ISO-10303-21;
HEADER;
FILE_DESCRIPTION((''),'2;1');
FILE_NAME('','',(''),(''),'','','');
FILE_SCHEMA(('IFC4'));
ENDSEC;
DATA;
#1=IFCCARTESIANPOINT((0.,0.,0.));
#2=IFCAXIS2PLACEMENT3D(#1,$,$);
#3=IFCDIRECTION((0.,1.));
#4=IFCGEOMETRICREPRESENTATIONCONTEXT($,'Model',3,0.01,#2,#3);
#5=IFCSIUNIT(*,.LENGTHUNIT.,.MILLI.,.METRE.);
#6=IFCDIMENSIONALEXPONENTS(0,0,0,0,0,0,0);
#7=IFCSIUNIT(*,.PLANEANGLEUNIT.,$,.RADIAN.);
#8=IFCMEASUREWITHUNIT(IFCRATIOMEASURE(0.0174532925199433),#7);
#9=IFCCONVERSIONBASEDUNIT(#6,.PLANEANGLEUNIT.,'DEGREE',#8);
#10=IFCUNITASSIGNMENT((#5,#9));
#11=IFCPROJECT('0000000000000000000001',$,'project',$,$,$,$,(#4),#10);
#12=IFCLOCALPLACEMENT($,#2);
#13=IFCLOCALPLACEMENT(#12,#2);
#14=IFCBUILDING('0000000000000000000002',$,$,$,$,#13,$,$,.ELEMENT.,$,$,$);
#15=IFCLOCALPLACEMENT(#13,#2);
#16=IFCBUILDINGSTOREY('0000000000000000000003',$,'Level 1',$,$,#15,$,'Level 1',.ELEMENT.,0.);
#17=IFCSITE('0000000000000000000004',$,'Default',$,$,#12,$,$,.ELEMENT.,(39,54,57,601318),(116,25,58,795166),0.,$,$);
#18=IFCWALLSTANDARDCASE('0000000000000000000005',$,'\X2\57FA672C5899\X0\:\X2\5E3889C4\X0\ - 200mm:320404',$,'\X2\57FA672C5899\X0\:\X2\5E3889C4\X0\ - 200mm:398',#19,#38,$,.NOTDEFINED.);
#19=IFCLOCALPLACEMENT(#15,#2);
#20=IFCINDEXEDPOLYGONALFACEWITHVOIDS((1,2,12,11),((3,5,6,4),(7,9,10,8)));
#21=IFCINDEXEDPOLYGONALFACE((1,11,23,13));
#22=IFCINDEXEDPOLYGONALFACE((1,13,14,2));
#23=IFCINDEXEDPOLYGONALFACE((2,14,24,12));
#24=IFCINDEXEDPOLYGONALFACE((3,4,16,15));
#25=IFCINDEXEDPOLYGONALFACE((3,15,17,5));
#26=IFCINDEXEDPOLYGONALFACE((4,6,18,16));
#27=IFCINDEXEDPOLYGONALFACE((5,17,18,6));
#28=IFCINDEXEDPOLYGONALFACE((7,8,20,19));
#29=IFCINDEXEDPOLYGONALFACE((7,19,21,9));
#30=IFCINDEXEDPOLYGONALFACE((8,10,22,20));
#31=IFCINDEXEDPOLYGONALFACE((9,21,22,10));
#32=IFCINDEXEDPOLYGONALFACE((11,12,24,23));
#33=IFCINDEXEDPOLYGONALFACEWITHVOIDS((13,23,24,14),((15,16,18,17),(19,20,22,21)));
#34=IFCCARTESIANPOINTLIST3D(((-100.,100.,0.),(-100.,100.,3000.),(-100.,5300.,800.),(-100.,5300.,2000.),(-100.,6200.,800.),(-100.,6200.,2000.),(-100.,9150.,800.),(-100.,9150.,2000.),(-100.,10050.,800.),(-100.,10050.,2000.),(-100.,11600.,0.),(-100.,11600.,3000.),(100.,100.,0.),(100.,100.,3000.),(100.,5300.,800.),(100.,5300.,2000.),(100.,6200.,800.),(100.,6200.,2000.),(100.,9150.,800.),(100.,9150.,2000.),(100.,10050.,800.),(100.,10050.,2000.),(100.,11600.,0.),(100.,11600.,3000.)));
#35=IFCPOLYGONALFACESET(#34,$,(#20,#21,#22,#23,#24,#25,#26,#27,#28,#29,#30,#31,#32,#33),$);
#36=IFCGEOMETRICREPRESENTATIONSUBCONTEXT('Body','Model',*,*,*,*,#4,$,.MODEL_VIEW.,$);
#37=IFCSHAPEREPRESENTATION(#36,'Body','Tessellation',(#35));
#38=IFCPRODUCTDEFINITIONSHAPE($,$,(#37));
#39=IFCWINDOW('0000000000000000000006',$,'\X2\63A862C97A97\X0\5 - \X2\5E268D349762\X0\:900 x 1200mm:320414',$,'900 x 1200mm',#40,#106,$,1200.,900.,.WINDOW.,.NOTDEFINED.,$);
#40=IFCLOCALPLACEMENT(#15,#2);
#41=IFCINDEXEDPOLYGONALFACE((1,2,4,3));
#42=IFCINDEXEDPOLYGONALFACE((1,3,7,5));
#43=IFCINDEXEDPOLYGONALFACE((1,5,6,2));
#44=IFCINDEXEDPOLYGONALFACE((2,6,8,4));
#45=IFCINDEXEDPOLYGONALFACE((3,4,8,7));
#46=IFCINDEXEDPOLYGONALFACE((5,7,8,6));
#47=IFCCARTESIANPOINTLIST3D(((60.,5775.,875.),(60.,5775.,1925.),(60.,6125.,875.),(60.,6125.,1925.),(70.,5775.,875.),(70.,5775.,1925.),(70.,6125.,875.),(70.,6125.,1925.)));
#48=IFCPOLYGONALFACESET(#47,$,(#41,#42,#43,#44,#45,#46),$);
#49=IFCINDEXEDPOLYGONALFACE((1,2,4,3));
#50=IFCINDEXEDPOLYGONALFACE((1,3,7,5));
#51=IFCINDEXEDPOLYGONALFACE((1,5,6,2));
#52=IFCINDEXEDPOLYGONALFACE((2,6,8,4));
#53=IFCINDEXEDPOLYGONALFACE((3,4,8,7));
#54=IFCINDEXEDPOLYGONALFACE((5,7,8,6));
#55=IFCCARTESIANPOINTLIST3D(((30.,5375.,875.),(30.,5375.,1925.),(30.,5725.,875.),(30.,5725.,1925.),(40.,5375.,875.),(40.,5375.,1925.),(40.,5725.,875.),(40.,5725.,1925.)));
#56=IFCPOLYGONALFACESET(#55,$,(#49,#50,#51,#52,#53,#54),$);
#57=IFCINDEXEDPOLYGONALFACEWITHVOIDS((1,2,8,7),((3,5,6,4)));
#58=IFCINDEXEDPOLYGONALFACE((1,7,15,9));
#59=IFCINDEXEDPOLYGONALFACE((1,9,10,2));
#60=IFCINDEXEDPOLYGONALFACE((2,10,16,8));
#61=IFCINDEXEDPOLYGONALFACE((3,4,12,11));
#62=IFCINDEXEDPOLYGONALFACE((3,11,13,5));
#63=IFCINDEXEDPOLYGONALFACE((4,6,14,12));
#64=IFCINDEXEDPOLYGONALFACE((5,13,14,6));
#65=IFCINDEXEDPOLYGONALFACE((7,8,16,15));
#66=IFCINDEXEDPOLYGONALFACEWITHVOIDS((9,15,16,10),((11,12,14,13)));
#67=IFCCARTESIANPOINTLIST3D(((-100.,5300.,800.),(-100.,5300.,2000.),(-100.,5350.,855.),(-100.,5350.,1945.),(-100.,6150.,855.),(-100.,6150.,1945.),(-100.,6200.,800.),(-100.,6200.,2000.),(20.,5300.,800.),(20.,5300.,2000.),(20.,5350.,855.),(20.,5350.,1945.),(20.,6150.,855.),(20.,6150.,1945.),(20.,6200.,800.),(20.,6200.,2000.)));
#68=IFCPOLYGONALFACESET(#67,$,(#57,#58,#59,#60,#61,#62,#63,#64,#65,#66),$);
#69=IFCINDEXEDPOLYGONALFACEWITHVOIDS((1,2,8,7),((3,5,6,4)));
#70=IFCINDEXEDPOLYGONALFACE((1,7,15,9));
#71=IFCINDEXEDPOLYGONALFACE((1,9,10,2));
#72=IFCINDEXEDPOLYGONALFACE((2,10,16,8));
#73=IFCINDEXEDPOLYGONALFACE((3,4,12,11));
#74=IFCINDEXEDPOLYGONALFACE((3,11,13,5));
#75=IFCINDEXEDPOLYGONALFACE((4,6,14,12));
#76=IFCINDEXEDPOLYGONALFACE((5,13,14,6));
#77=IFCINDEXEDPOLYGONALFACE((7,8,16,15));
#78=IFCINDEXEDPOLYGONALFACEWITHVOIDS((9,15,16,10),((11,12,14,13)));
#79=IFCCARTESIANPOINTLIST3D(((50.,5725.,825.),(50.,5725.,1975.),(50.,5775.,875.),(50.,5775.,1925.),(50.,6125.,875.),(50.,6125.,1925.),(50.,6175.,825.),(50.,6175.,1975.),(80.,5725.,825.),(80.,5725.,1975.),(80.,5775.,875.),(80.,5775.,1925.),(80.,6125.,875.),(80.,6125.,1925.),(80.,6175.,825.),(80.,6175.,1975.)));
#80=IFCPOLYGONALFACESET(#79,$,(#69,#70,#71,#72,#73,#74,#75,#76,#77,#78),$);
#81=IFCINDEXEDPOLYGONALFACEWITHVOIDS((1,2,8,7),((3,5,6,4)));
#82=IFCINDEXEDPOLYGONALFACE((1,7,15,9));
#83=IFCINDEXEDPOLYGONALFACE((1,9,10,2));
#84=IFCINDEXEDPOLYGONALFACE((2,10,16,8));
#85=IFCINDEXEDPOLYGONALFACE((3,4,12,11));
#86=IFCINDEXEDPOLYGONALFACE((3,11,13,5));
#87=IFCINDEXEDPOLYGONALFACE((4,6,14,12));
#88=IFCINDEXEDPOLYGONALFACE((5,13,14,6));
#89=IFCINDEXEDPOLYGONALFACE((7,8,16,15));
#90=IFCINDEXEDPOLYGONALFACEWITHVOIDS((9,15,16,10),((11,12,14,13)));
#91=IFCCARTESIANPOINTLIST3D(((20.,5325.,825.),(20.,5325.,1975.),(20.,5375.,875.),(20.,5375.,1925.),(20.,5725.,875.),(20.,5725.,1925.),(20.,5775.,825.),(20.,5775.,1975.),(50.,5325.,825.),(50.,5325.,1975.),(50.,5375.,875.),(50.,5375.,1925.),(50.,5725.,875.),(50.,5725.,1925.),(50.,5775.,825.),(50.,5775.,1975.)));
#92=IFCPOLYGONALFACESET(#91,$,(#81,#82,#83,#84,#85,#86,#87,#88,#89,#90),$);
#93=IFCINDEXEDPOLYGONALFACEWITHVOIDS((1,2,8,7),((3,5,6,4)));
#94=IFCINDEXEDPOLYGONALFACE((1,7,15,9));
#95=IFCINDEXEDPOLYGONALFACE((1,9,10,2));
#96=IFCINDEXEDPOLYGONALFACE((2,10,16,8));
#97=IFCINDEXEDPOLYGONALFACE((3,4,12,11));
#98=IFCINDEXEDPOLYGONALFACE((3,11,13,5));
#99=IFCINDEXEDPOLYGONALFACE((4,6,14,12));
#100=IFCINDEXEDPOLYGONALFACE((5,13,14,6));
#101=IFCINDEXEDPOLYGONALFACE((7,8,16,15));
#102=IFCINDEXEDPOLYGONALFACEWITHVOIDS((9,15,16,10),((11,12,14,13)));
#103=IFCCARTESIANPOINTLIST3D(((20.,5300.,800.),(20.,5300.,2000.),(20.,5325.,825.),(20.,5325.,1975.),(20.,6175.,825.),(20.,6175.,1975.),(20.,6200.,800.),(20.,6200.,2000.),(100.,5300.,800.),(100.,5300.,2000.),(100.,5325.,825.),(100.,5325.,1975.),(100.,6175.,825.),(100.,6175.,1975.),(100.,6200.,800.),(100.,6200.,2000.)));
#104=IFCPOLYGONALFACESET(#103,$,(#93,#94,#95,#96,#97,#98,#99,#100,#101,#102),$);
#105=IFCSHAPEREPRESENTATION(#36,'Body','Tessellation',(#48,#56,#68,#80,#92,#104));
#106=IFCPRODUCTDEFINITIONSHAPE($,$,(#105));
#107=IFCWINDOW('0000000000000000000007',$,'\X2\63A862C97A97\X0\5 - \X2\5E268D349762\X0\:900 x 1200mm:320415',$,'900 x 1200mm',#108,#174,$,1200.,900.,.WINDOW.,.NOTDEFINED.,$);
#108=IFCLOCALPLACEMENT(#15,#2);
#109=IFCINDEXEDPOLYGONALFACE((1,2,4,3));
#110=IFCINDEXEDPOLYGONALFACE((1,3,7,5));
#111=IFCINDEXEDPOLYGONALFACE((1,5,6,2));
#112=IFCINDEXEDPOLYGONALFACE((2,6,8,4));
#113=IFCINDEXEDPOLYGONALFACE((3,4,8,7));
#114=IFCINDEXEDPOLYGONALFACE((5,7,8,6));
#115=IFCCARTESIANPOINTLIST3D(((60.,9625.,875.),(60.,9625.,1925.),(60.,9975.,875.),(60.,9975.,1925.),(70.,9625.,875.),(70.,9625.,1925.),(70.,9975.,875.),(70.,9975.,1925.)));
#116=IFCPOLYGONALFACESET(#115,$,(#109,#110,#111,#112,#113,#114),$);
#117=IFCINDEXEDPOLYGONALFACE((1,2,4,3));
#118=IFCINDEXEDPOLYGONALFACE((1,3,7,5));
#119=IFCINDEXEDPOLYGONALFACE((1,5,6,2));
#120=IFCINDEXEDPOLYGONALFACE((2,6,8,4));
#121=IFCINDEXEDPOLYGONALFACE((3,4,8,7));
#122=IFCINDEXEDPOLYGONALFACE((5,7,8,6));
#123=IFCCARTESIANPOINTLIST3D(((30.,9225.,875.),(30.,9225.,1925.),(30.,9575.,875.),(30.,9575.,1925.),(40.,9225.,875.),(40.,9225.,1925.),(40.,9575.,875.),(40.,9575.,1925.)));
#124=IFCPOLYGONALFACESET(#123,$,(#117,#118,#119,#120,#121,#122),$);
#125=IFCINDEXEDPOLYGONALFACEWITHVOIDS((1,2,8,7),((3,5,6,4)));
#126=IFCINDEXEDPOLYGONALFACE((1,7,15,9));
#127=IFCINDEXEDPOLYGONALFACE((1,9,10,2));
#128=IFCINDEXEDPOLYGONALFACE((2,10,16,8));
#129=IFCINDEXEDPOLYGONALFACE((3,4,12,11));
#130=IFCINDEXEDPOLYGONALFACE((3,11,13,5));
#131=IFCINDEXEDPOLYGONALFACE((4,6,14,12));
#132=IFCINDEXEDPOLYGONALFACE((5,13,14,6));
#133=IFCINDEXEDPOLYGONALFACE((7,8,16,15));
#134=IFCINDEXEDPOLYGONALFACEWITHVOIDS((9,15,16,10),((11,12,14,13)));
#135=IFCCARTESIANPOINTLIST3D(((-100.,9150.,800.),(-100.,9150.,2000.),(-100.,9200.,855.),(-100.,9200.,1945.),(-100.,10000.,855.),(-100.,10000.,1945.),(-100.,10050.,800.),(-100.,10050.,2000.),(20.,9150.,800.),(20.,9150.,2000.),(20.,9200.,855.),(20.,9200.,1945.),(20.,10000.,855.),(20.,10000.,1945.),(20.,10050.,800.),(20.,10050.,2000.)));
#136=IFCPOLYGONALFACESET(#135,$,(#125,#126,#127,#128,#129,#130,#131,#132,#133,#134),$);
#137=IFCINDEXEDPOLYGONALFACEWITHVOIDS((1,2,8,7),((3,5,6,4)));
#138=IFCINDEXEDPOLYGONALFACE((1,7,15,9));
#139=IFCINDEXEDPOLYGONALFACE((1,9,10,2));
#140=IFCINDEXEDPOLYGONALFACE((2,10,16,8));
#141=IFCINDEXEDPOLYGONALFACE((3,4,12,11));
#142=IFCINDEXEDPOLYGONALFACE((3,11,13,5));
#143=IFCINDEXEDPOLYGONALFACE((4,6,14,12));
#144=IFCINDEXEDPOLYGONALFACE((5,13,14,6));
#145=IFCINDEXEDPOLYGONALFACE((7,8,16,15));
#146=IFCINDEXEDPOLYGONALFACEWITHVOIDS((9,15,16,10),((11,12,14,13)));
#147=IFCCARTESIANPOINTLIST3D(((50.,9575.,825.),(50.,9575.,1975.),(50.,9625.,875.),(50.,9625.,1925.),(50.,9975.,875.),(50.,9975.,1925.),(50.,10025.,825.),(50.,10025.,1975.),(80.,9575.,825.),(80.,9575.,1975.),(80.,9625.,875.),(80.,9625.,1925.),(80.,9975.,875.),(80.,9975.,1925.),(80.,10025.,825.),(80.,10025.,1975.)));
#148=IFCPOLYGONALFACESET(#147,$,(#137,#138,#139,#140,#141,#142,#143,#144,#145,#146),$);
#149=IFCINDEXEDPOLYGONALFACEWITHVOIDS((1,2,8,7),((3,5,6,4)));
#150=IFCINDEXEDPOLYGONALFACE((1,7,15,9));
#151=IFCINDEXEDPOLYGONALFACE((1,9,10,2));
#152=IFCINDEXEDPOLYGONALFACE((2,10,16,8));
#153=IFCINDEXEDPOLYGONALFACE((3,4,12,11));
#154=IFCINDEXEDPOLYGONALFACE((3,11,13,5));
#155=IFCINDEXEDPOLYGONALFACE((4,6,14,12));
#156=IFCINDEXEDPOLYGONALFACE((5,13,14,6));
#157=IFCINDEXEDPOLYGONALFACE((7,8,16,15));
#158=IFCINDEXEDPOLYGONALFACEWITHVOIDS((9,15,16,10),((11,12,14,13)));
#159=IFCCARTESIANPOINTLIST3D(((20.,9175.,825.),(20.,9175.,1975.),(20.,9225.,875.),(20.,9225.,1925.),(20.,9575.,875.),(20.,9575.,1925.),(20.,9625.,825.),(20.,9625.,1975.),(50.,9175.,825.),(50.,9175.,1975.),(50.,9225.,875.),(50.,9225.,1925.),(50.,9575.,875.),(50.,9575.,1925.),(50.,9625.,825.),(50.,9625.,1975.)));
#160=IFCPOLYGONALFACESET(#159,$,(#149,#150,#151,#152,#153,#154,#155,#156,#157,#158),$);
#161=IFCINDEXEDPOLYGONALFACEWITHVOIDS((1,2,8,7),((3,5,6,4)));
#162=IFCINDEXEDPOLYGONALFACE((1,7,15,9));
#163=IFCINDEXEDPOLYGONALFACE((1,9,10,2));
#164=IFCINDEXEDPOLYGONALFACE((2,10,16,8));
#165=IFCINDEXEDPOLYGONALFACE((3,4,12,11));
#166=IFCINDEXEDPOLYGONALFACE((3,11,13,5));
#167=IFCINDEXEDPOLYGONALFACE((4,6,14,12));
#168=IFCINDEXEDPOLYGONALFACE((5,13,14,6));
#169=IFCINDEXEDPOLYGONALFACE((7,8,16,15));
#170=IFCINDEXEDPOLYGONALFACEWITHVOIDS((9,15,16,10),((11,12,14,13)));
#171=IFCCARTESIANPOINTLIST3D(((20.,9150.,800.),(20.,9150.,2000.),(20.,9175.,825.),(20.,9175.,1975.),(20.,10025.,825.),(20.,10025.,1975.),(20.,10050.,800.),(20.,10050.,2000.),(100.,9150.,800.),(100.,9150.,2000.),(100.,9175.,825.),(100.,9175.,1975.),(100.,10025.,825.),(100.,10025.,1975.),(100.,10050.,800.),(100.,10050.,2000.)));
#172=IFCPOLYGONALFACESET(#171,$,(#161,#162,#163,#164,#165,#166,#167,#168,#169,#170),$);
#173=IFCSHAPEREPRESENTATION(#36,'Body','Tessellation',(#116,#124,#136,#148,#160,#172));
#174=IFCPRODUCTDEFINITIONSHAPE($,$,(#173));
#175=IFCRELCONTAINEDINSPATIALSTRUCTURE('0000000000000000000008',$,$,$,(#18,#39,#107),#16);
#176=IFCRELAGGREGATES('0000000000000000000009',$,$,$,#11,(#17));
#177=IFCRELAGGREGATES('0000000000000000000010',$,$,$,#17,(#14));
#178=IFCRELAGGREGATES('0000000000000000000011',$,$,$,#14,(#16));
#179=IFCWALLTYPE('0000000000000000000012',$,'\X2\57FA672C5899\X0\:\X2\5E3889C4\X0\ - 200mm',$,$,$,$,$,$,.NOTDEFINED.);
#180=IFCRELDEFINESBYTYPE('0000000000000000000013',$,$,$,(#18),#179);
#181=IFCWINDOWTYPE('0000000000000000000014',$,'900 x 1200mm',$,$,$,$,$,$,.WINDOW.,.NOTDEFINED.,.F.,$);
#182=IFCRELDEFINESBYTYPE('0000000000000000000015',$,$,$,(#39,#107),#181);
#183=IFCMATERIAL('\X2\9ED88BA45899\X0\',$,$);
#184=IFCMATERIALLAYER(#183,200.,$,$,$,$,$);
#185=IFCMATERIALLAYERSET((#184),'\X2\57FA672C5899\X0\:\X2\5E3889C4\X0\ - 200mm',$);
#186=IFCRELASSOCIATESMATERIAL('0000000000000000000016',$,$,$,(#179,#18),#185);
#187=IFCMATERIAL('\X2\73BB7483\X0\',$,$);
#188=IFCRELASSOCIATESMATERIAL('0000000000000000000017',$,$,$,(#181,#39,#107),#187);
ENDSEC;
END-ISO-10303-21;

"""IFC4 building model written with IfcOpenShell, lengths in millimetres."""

from ifc_helpers import new_model, entity, si_unit, converted_unit, direction, frame, frame_2d, origin, origin_2d_with_axis, place, context, subcontext, project, spatial, polyline, rectangle, outline, extrude, source, transform, mapped, material, layer, layer_set, layer_usage, type_object, type_shapes, element, fill, save


model = new_model("IFC4")

# Units and contexts
model_context = context("Model", 3, precision=0.01, world=origin(), true_north=direction((0.0, 1.0)))
body_context = subcontext(model_context, "Body", "Model", "MODEL_VIEW")
ifc_project = project(units=[si_unit("LENGTHUNIT", "METRE", prefix="MILLI"), converted_unit("PLANEANGLEUNIT", "DEGREE", entity("IfcRatioMeasure", 0.0174532925199433), si_unit("PLANEANGLEUNIT", "RADIAN"), dimensions=[0, 0, 0, 0, 0, 0, 0])], contexts=[model_context])

# Site, building, storey
site_placement = place(None, origin())
site = spatial("IfcSite", under=ifc_project, at=site_placement, Name="Default", CompositionType="ELEMENT", RefLatitude=(39, 54, 57, 601318), RefLongitude=(116, 25, 58, 795166), RefElevation=0.0)
building_placement = place(site_placement, origin())
building = spatial("IfcBuilding", under=site, at=building_placement, CompositionType="ELEMENT")
storey_placement = place(building_placement, origin())
storey = spatial("IfcBuildingStorey", under=building, at=storey_placement, Name="Level 1", LongName="Level 1", CompositionType="ELEMENT", Elevation=0.0)

# Wall, openings, windows
ifc_material_1 = material(Name="默认墙")
ifc_layer_1 = layer(ifc_material_1, 200.0)
ifc_layer_set_1 = layer_set([ifc_layer_1], Name="基本墙:常规 - 200mm")
ifc_layer_usage_1 = layer_usage(ifc_layer_set_1, "AXIS2", "NEGATIVE", 100.0)
wall_type = type_object("IfcWallType", Name="基本墙:常规 - 200mm", PredefinedType="NOTDEFINED", material=ifc_layer_set_1)
wall_1_placement = place(storey_placement, frame((0.0, 100.0, 0.0), z_axis=(0.0, 0.0, 1.0), x_axis=(0.0, 1.0, 0.0)))
wall_1 = element("IfcWallStandardCase", 1, at=wall_1_placement, inside=storey, type_object=wall_type, material=ifc_layer_usage_1, Name="基本墙:常规 - 200mm:320404", ObjectType="基本墙:常规 - 200mm:398", PredefinedType="NOTDEFINED", context=body_context, shape_type="SweptSolid", body=[
    extrude(rectangle(XDim=11500.0, YDim=200.0, at=frame_2d((5750.0, 0.0), x_axis=(-1.0, 0.0))), origin(), (0.0, 0.0, 1.0), 3000.0),
])
opening_1_placement = place(wall_1_placement, frame((6100.0, 100.0, 800.0)))
opening_1 = element("IfcOpeningElement", 2, at=opening_1_placement, cuts=wall_1, ObjectType="Opening", PredefinedType="OPENING", context=body_context, shape_type="SweptSolid", body=[
    extrude(rectangle(XDim=1200.0, YDim=900.0, at=frame_2d((600.0, 450.0), x_axis=(-1.0, 0.0))), frame((0.0, 0.0, 0.0), z_axis=(0.0, -1.0, 0.0), x_axis=(0.0, 0.0, 1.0)), (0.0, 0.0, 1.0), 200.0),
])
opening_2_placement = place(wall_1_placement, frame((9950.0, 100.0, 800.0)))
opening_2 = element("IfcOpeningElement", 3, at=opening_2_placement, cuts=wall_1, ObjectType="Opening", PredefinedType="OPENING", context=body_context, shape_type="SweptSolid", body=[
    extrude(rectangle(XDim=1200.0, YDim=900.0, at=frame_2d((600.0, 450.0), x_axis=(-1.0, 0.0))), frame((0.0, 0.0, 0.0), z_axis=(0.0, -1.0, 0.0), x_axis=(0.0, 0.0, 1.0)), (0.0, 0.0, 1.0), 200.0),
])
ifc_material_2 = material(Name="玻璃")
window_type_1 = type_object("IfcWindowType", Name="900 x 1200mm", ParameterTakesPrecedence=False, PartitioningType="NOTDEFINED", PredefinedType="WINDOW", material=ifc_material_2)
shared_shape_1 = source(origin(), body_context, "Body", "SweptSolid", [
    extrude(rectangle(XDim=10.0, YDim=350.0, at=origin_2d_with_axis()), frame((250.0, 165.0, 75.0), z_axis=(0.0, 0.0, 1.0), x_axis=(0.0, -1.0, 0.0)), (0.0, 0.0, 1.0), 1050.0),
    extrude(rectangle(XDim=10.0, YDim=350.0, at=origin_2d_with_axis()), frame((650.0, 135.0, 75.0), z_axis=(0.0, 0.0, 1.0), x_axis=(0.0, -1.0, 0.0)), (0.0, 0.0, 1.0), 1050.0),
    extrude(outline(polyline([(-450.0, -600.0), (450.0, -600.0), (450.0, 600.0), (-450.0, 600.0), (-450.0, -600.0)]), holes=[polyline([(400.0, -545.0), (-400.0, -545.0), (-400.0, 545.0), (400.0, 545.0), (400.0, -545.0)])]), frame((450.0, 0.0, 600.0), z_axis=(0.0, 1.0, 0.0), x_axis=(1.0, 0.0, 0.0)), (0.0, 0.0, 1.0), 120.0),
    extrude(outline(polyline([(-225.0, -575.0), (225.0, -575.0), (225.0, 575.0), (-225.0, 575.0), (-225.0, -575.0)]), holes=[polyline([(-175.0, -525.0), (-175.0, 525.0), (175.0, 525.0), (175.0, -525.0), (-175.0, -525.0)])]), frame((250.0, 150.0, 600.0), z_axis=(0.0, 1.0, 0.0), x_axis=(-1.0, 0.0, 0.0)), (0.0, 0.0, 1.0), 30.0),
    extrude(outline(polyline([(-225.0, -575.0), (225.0, -575.0), (225.0, 575.0), (-225.0, 575.0), (-225.0, -575.0)]), holes=[polyline([(-175.0, -525.0), (-175.0, 525.0), (175.0, 525.0), (175.0, -525.0), (-175.0, -525.0)])]), frame((650.0, 120.0, 600.0), z_axis=(0.0, 1.0, 0.0), x_axis=(1.0, 0.0, 0.0)), (0.0, 0.0, 1.0), 30.0),
    extrude(outline(polyline([(-450.0, -600.0), (450.0, -600.0), (450.0, 600.0), (-450.0, 600.0), (-450.0, -600.0)]), holes=[polyline([(-425.0, 575.0), (425.0, 575.0), (425.0, -575.0), (-425.0, -575.0), (-425.0, 575.0)])]), frame((450.0, 120.0, 600.0), z_axis=(0.0, 1.0, 0.0), x_axis=(1.0, 0.0, 0.0)), (0.0, 0.0, 1.0), 80.0),
])
type_shapes(window_type_1, [shared_shape_1])
window_1_placement = place(opening_1_placement, frame((0.0, 0.0, 0.0), z_axis=(0.0, 0.0, 1.0), x_axis=(-1.0, 0.0, 0.0)))
window_1 = element("IfcWindow", 4, at=window_1_placement, inside=storey, type_object=window_type_1, material=ifc_material_2, Name="推拉窗5 - 带贴面:900 x 1200mm:320414", ObjectType="900 x 1200mm", OverallHeight=1200.0, OverallWidth=900.0, PartitioningType="NOTDEFINED", PredefinedType="WINDOW", context=body_context, shape_type="MappedRepresentation", body=[
    mapped(shared_shape_1, transform((0.0, 0.0, 0.0), scale=1.0)),
])
fill(opening_1, window_1)
window_2_placement = place(opening_2_placement, frame((0.0, 0.0, 0.0), z_axis=(0.0, 0.0, 1.0), x_axis=(-1.0, 0.0, 0.0)))
window_2 = element("IfcWindow", 5, at=window_2_placement, inside=storey, type_object=window_type_1, material=ifc_material_2, Name="推拉窗5 - 带贴面:900 x 1200mm:320415", ObjectType="900 x 1200mm", OverallHeight=1200.0, OverallWidth=900.0, PartitioningType="NOTDEFINED", PredefinedType="WINDOW", context=body_context, shape_type="MappedRepresentation", body=[
    mapped(shared_shape_1, transform((0.0, 0.0, 0.0), scale=1.0)),
])
fill(opening_2, window_2)

save(model, "model.ifc")
